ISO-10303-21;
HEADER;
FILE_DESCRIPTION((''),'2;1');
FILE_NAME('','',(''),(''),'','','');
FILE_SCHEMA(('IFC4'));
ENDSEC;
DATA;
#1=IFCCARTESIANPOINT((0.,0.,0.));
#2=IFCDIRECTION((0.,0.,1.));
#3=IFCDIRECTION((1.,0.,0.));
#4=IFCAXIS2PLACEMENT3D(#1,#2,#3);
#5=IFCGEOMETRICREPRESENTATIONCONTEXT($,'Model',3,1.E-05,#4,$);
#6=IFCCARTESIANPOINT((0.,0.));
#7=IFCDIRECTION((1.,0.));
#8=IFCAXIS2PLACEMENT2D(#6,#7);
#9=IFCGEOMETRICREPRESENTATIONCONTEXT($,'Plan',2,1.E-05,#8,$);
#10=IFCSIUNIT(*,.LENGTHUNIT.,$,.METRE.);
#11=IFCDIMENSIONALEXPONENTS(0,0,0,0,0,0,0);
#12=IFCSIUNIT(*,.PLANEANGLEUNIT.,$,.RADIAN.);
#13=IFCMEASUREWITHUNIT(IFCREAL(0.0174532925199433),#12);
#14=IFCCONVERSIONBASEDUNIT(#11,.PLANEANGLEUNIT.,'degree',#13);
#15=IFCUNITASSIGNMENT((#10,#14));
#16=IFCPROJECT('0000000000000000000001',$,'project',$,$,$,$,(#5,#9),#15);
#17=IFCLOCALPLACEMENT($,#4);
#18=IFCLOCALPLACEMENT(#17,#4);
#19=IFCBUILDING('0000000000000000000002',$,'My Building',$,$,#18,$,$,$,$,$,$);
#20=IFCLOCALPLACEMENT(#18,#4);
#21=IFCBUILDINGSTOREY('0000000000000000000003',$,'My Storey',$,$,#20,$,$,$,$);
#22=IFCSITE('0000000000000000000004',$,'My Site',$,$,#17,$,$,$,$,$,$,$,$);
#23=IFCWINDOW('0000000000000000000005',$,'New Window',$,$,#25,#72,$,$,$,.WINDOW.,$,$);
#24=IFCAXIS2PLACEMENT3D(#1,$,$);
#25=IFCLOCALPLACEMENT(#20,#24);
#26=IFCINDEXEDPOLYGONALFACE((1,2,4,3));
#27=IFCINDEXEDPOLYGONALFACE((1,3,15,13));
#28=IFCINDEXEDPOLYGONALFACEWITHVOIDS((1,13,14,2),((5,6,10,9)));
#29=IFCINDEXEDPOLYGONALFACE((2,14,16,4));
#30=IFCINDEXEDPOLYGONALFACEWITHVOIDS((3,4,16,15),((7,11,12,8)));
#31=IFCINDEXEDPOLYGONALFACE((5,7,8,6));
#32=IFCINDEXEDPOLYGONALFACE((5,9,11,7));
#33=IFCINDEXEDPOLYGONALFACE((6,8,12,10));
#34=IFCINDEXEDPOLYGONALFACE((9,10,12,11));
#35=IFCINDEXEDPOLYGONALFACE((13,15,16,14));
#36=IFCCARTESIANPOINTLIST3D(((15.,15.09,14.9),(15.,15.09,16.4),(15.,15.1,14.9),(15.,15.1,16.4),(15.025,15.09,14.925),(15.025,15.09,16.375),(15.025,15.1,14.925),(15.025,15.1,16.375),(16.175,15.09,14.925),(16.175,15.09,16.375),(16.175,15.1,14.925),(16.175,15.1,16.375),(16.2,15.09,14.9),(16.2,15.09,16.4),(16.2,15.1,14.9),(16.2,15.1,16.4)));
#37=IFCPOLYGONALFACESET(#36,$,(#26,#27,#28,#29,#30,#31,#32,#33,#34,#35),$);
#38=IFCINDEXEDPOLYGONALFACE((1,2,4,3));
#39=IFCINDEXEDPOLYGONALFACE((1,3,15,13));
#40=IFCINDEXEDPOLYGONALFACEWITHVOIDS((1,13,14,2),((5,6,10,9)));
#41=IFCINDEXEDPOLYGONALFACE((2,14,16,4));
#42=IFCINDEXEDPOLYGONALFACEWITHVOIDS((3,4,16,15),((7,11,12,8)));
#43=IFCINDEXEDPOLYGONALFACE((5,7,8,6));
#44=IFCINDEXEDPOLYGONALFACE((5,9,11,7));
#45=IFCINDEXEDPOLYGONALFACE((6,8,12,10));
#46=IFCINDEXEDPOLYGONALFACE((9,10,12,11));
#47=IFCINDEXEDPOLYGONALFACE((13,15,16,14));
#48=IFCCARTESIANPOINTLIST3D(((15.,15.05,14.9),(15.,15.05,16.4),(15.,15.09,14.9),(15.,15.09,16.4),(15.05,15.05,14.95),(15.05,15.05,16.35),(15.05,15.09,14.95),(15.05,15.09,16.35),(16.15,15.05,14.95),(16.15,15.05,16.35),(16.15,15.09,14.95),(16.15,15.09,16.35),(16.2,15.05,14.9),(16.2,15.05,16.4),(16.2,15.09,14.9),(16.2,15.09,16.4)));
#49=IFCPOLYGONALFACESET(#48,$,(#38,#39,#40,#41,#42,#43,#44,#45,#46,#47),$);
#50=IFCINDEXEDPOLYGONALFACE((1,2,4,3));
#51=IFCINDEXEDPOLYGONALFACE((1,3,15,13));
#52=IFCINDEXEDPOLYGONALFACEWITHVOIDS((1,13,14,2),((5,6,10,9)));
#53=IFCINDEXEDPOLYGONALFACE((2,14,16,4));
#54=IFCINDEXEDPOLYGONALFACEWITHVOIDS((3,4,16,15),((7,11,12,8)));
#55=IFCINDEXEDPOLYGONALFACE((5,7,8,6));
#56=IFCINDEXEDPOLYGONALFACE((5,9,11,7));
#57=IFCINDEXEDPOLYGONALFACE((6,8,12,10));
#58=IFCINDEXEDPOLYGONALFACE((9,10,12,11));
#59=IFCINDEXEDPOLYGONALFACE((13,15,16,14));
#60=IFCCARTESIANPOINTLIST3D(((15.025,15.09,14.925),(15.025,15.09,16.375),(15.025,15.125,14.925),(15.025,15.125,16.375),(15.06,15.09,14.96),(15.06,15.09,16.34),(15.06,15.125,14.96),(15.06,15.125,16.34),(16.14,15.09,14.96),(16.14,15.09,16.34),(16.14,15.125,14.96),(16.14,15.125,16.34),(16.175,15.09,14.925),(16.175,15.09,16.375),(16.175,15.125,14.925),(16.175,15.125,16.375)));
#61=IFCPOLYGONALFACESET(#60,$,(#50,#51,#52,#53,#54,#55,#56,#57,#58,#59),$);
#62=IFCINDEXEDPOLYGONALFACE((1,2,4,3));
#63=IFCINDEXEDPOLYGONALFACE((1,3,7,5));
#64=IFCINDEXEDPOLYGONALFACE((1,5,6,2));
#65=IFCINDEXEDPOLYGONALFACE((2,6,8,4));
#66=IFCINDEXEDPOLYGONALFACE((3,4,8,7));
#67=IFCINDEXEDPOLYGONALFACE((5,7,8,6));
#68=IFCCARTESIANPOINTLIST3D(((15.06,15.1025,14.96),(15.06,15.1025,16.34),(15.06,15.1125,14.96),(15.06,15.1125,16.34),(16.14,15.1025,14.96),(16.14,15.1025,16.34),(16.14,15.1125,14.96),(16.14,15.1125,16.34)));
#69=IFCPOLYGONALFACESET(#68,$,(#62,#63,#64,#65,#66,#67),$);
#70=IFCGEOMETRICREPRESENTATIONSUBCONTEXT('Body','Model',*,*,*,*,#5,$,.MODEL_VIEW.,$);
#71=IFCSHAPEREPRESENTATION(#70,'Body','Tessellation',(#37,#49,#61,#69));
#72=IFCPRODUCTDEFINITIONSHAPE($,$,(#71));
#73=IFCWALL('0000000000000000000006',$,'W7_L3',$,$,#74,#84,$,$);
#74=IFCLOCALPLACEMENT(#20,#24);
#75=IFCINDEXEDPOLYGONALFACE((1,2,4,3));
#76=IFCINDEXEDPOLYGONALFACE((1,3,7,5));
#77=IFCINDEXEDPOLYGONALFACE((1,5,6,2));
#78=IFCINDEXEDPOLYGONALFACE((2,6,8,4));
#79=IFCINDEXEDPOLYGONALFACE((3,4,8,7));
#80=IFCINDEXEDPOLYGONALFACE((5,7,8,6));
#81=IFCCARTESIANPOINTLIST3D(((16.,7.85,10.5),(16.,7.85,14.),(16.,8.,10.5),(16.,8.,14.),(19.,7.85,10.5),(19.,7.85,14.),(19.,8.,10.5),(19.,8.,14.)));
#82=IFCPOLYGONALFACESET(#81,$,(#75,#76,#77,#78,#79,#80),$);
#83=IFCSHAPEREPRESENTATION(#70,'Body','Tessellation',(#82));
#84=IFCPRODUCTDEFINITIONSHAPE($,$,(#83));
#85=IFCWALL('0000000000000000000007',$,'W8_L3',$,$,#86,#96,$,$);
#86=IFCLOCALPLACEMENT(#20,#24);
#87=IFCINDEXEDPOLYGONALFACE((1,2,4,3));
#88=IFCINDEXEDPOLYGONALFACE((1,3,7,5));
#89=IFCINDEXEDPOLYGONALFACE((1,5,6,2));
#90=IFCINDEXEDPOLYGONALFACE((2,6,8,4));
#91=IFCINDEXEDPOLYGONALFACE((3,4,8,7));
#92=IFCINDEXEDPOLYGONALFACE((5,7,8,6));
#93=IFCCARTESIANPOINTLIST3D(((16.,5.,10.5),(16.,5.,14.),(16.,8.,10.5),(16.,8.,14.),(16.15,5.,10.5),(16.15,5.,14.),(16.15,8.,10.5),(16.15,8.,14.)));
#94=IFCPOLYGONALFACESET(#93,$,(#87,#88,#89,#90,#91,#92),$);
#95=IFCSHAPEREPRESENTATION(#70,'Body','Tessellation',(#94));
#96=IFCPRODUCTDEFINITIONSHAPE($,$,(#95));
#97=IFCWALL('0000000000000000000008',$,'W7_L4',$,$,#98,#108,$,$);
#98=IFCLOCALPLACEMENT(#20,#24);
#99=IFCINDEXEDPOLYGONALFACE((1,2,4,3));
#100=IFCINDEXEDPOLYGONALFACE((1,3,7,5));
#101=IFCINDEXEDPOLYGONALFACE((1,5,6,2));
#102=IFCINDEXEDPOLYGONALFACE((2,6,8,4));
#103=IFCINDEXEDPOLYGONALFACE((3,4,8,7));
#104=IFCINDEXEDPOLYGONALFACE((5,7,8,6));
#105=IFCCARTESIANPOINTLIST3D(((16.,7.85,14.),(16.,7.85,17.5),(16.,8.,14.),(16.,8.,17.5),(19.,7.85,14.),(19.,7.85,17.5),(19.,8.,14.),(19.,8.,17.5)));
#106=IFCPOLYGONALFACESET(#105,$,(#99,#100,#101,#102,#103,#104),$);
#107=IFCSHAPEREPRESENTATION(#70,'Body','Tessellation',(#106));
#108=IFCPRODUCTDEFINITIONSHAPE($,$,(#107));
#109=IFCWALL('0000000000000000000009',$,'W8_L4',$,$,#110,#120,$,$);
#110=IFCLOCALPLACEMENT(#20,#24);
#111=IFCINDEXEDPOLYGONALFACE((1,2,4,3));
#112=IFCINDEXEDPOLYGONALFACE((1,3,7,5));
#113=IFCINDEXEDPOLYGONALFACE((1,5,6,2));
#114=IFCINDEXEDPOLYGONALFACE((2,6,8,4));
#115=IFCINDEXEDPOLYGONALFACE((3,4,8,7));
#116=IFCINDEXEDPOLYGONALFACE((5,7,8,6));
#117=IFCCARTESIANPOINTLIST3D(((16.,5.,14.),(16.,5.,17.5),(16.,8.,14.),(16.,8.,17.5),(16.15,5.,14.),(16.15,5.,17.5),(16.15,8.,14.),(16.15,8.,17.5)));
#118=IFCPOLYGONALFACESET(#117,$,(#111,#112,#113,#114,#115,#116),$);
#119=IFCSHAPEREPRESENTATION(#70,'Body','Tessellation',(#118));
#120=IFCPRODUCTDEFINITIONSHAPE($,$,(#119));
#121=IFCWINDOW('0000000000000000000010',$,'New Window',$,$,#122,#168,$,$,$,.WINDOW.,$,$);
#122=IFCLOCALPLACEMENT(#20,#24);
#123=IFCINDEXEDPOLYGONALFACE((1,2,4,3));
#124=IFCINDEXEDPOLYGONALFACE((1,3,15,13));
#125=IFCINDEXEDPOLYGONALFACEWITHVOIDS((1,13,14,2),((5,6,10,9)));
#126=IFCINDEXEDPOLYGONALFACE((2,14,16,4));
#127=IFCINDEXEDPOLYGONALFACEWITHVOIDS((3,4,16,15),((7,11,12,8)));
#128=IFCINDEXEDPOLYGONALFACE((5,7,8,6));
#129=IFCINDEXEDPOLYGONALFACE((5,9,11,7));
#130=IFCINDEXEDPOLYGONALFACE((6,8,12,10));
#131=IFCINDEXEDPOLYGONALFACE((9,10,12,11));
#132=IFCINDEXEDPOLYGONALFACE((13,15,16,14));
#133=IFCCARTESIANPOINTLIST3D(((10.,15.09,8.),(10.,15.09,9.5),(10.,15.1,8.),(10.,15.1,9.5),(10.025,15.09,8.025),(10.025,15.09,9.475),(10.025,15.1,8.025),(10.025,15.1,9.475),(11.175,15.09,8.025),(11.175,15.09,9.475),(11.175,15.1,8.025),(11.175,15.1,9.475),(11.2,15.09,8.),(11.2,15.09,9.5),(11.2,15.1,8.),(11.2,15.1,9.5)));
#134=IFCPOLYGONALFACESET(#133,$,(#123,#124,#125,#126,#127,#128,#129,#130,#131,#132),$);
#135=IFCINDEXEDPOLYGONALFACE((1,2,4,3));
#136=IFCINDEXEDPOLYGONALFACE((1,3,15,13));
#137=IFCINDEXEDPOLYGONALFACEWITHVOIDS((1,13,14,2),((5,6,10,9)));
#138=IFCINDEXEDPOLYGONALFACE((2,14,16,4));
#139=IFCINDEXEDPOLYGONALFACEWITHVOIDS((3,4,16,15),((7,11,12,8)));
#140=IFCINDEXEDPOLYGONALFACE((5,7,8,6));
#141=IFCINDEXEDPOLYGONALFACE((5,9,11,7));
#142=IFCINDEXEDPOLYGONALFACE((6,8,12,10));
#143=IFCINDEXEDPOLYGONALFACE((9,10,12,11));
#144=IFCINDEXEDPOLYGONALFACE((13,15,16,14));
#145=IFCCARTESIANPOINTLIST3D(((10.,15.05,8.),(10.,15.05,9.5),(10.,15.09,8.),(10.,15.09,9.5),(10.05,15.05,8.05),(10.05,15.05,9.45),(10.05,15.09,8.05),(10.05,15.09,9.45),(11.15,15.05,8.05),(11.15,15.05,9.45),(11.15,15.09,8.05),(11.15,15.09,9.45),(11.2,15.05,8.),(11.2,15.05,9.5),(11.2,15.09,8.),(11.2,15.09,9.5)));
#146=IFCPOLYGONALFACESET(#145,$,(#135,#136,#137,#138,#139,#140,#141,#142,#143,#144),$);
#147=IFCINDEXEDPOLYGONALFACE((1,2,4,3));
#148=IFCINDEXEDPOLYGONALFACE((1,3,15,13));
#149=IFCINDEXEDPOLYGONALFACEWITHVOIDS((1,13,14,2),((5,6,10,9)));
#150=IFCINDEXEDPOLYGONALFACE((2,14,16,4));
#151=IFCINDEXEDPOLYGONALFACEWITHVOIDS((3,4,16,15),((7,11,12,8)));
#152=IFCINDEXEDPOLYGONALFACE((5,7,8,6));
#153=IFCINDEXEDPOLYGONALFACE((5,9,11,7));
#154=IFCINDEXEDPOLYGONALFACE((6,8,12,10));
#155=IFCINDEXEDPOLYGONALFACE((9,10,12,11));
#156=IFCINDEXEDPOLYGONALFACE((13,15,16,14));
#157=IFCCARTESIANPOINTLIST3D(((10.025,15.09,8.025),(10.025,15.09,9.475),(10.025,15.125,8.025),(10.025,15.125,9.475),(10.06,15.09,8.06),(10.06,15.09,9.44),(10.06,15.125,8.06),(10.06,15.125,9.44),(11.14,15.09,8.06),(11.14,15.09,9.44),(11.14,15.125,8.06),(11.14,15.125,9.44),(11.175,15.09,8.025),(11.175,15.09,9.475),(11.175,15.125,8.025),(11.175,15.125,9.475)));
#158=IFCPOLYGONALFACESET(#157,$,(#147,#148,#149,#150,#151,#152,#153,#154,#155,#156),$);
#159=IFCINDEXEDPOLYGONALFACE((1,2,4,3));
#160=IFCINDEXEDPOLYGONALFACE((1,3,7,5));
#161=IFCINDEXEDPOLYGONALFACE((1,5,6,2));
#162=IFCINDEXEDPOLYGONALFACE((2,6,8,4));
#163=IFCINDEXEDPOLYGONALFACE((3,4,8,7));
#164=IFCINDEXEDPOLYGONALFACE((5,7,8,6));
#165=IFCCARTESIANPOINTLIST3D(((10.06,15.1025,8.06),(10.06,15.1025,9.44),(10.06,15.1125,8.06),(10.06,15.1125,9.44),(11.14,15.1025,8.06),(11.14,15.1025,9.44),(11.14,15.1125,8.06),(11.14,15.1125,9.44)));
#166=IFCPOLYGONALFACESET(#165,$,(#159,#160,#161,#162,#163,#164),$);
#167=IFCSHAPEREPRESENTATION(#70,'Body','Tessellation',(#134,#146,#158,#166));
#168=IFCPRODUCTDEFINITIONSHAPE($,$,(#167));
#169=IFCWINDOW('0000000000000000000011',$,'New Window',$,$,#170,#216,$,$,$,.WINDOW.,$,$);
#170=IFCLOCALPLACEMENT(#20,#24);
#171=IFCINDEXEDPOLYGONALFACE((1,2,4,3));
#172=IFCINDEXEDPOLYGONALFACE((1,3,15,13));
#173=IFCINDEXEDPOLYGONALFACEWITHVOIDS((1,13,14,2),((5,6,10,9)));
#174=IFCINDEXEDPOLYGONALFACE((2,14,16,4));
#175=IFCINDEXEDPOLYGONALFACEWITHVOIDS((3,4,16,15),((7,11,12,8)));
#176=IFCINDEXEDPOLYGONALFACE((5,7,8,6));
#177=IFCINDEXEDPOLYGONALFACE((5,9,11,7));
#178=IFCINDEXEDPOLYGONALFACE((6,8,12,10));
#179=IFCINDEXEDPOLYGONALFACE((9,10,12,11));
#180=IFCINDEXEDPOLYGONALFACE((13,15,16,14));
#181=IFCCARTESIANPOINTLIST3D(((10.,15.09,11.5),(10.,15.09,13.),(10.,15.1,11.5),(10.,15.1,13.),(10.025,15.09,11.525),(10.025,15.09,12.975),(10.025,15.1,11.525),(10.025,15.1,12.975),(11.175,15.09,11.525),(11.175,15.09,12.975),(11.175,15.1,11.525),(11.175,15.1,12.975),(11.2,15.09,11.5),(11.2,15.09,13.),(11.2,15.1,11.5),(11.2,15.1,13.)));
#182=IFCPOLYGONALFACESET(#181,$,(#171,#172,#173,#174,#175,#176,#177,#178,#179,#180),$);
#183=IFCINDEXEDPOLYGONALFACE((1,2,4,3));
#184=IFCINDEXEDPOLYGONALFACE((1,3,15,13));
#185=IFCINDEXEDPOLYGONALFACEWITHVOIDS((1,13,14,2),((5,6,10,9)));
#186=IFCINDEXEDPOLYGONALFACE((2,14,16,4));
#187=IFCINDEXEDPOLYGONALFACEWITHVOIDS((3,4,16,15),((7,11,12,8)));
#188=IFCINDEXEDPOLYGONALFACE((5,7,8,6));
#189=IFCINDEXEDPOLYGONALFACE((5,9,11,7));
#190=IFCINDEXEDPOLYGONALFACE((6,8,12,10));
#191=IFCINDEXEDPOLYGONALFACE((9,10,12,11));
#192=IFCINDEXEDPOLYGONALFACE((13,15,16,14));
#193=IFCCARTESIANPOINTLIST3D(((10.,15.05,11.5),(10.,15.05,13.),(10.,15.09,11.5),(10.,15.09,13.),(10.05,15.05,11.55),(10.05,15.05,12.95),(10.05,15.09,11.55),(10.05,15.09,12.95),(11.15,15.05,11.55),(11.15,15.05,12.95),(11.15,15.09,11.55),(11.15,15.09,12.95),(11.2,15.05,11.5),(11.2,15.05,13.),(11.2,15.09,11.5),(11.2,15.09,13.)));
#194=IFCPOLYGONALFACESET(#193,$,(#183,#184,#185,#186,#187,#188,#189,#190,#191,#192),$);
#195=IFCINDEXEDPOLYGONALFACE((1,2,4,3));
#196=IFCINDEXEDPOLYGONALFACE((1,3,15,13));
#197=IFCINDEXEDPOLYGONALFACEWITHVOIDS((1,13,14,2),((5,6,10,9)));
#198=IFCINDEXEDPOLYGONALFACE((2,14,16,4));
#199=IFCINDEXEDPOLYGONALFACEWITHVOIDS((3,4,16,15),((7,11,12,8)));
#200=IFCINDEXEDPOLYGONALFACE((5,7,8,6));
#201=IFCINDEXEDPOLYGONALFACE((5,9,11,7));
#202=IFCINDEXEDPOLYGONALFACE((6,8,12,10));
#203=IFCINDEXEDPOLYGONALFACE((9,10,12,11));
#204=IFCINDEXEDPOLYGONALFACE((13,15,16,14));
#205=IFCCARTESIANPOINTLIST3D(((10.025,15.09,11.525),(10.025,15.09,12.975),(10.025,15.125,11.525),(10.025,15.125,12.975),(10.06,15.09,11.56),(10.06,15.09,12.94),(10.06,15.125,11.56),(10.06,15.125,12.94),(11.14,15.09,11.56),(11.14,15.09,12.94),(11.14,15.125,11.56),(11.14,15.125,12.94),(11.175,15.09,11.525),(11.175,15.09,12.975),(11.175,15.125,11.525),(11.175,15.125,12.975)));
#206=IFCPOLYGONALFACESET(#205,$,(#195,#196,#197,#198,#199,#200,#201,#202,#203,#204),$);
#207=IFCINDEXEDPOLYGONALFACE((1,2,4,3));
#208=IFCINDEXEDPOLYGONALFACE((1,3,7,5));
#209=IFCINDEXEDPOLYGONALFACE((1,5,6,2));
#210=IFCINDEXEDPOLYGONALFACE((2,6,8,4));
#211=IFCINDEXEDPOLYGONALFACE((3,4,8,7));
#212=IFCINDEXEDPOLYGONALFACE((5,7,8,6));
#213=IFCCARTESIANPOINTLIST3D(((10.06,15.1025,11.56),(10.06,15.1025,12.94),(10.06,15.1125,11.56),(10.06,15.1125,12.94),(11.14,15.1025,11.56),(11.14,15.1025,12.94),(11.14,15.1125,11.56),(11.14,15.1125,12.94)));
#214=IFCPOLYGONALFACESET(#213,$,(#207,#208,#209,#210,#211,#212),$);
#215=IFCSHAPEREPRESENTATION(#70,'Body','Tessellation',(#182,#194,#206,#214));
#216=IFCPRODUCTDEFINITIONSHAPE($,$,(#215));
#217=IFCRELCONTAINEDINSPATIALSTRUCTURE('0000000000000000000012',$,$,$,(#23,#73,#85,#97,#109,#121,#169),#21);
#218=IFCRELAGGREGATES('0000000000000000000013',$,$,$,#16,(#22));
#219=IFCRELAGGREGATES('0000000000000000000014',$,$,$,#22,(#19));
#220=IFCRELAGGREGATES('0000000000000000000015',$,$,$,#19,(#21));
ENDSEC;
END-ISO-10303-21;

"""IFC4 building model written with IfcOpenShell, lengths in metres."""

from ifc_helpers import new_model, entity, si_unit, converted_unit, frame, origin_with_axes, origin_2d_with_axis, place, context, subcontext, project, spatial, line, indexed_curve, outline, extrude, element, save


model = new_model("IFC4")

# Units and contexts
model_context = context("Model", 3, precision=1e-05, world=origin_with_axes())
plan_context = context("Plan", 2, precision=1e-05, world=origin_2d_with_axis())
body_context = subcontext(model_context, "Body", "Model", "MODEL_VIEW")
ifc_project = project(units=[si_unit("LENGTHUNIT", "METRE"), converted_unit("PLANEANGLEUNIT", "degree", entity("IfcReal", 0.0174532925199433), si_unit("PLANEANGLEUNIT", "RADIAN"), dimensions=[0, 0, 0, 0, 0, 0, 0])], contexts=[model_context, plan_context])

# Site, building, storey
site_placement = place(None, origin_with_axes())
site = spatial("IfcSite", under=ifc_project, at=site_placement, Name="My Site")
building_placement = place(site_placement, origin_with_axes())
building = spatial("IfcBuilding", under=site, at=building_placement, Name="My Building")
storey_placement = place(building_placement, origin_with_axes())
storey = spatial("IfcBuildingStorey", under=building, at=storey_placement, Name="My Storey")

# Window
for number, where, z_axis, x_axis, name in (
    (1, (15.0, 15.0, 14.9), (0.0, 0.0, 1.0), (1.0, 0.0, 0.0), "New Window"),
):
    element("IfcWindow", number, at=place(storey_placement, frame(where, z_axis=z_axis, x_axis=x_axis)), inside=storey, Name=name, PredefinedType="WINDOW", context=body_context, shape_type="SweptSolid", body=[
        extrude(outline(indexed_curve([(0.0, 0.0), (1.2, 0.0), (1.2, 1.5), (0.0, 1.5)], segments=[line(1, 2, 3, 4, 1)]), holes=[indexed_curve([(0.025, 0.025), (1.175, 0.025), (1.175, 1.475), (0.025, 1.475)], segments=[line(1, 2, 3, 4, 1)])]), frame((0.0, 0.09, 0.0), z_axis=(0.0, -1.0, 0.0), x_axis=(1.0, 0.0, 0.0)), (0.0, 0.0, -1.0), 0.01),
        extrude(outline(indexed_curve([(0.0, 0.0), (1.2, 0.0), (1.2, 1.5), (0.0, 1.5)], segments=[line(1, 2, 3, 4, 1)]), holes=[indexed_curve([(0.05, 0.05), (1.15, 0.05), (1.15, 1.45), (0.05, 1.45)], segments=[line(1, 2, 3, 4, 1)])]), frame((0.0, 0.05, 0.0), z_axis=(0.0, -1.0, 0.0), x_axis=(1.0, 0.0, 0.0)), (0.0, 0.0, -1.0), 0.04),
        extrude(outline(indexed_curve([(0.0, 0.0), (1.15, 0.0), (1.15, 1.45), (0.0, 1.45)], segments=[line(1, 2, 3, 4, 1)]), holes=[indexed_curve([(0.035, 0.035), (1.115, 0.035), (1.115, 1.415), (0.035, 1.415)], segments=[line(1, 2, 3, 4, 1)])]), frame((0.025, 0.09, 0.025), z_axis=(0.0, -1.0, 0.0), x_axis=(1.0, 0.0, 0.0)), (0.0, 0.0, -1.0), 0.035),
        extrude(outline(indexed_curve([(0.035, 0.035), (1.115, 0.035), (1.115, 1.415), (0.035, 1.415)], segments=[line(1, 2, 3, 4, 1)])), frame((0.025, 0.1025, 0.025), z_axis=(0.0, -1.0, 0.0), x_axis=(1.0, 0.0, 0.0)), (0.0, 0.0, -1.0), 0.01),
    ])

# Walls
for number, where, z_axis, x_axis, name in (
    (2, (19.0, 8.0, 10.5), (0.0, 0.0, 1.0), (-1.0, 0.0, 0.0), "W7_L3"),
    (3, (16.0, 8.0, 10.5), (0.0, 0.0, 1.0), (0.0, -1.0, 0.0), "W8_L3"),
):
    element("IfcWall", number, at=place(storey_placement, frame(where, z_axis=z_axis, x_axis=x_axis)), inside=storey, Name=name, context=body_context, shape_type="SweptSolid", body=[
        extrude(outline(indexed_curve([(0.0, 0.0), (0.0, 0.15), (3.0, 0.15), (3.0, 0.0), (0.0, 0.0)], self_intersect=False)), origin_with_axes(), (0.0, 0.0, 1.0), 3.5),
    ])
for number, where, z_axis, x_axis, name in (
    (4, (19.0, 8.0, 14.0), (0.0, 0.0, 1.0), (-1.0, 0.0, 0.0), "W7_L4"),
    (5, (16.0, 8.0, 14.0), (0.0, 0.0, 1.0), (0.0, -1.0, 0.0), "W8_L4"),
):
    element("IfcWall", number, at=place(storey_placement, frame(where, z_axis=z_axis, x_axis=x_axis)), inside=storey, Name=name, context=body_context, shape_type="SweptSolid", body=[
        extrude(outline(indexed_curve([(0.0, 0.0), (0.0, 0.15), (3.0, 0.15), (3.0, 0.0), (0.0, 0.0)], self_intersect=False)), origin_with_axes(), (0.0, 0.0, 1.0), 3.5),
    ])

# Windows
for number, where, z_axis, x_axis, name in (
    (6, (10.0, 15.0, 8.0), (0.0, 0.0, 1.0), (1.0, 0.0, 0.0), "New Window"),
    (7, (10.0, 15.0, 11.5), (0.0, 0.0, 1.0), (1.0, 0.0, 0.0), "New Window"),
):
    element("IfcWindow", number, at=place(storey_placement, frame(where, z_axis=z_axis, x_axis=x_axis)), inside=storey, Name=name, PredefinedType="WINDOW", context=body_context, shape_type="SweptSolid", body=[
        extrude(outline(indexed_curve([(0.0, 0.0), (1.2, 0.0), (1.2, 1.5), (0.0, 1.5)], segments=[line(1, 2, 3, 4, 1)]), holes=[indexed_curve([(0.025, 0.025), (1.175, 0.025), (1.175, 1.475), (0.025, 1.475)], segments=[line(1, 2, 3, 4, 1)])]), frame((0.0, 0.09, 0.0), z_axis=(0.0, -1.0, 0.0), x_axis=(1.0, 0.0, 0.0)), (0.0, 0.0, -1.0), 0.01),
        extrude(outline(indexed_curve([(0.0, 0.0), (1.2, 0.0), (1.2, 1.5), (0.0, 1.5)], segments=[line(1, 2, 3, 4, 1)]), holes=[indexed_curve([(0.05, 0.05), (1.15, 0.05), (1.15, 1.45), (0.05, 1.45)], segments=[line(1, 2, 3, 4, 1)])]), frame((0.0, 0.05, 0.0), z_axis=(0.0, -1.0, 0.0), x_axis=(1.0, 0.0, 0.0)), (0.0, 0.0, -1.0), 0.04),
        extrude(outline(indexed_curve([(0.0, 0.0), (1.15, 0.0), (1.15, 1.45), (0.0, 1.45)], segments=[line(1, 2, 3, 4, 1)]), holes=[indexed_curve([(0.035, 0.035), (1.115, 0.035), (1.115, 1.415), (0.035, 1.415)], segments=[line(1, 2, 3, 4, 1)])]), frame((0.025, 0.09, 0.025), z_axis=(0.0, -1.0, 0.0), x_axis=(1.0, 0.0, 0.0)), (0.0, 0.0, -1.0), 0.035),
        extrude(outline(indexed_curve([(0.035, 0.035), (1.115, 0.035), (1.115, 1.415), (0.035, 1.415)], segments=[line(1, 2, 3, 4, 1)])), frame((0.025, 0.1025, 0.025), z_axis=(0.0, -1.0, 0.0), x_axis=(1.0, 0.0, 0.0)), (0.0, 0.0, -1.0), 0.01),
    ])

save(model, "model.ifc")
